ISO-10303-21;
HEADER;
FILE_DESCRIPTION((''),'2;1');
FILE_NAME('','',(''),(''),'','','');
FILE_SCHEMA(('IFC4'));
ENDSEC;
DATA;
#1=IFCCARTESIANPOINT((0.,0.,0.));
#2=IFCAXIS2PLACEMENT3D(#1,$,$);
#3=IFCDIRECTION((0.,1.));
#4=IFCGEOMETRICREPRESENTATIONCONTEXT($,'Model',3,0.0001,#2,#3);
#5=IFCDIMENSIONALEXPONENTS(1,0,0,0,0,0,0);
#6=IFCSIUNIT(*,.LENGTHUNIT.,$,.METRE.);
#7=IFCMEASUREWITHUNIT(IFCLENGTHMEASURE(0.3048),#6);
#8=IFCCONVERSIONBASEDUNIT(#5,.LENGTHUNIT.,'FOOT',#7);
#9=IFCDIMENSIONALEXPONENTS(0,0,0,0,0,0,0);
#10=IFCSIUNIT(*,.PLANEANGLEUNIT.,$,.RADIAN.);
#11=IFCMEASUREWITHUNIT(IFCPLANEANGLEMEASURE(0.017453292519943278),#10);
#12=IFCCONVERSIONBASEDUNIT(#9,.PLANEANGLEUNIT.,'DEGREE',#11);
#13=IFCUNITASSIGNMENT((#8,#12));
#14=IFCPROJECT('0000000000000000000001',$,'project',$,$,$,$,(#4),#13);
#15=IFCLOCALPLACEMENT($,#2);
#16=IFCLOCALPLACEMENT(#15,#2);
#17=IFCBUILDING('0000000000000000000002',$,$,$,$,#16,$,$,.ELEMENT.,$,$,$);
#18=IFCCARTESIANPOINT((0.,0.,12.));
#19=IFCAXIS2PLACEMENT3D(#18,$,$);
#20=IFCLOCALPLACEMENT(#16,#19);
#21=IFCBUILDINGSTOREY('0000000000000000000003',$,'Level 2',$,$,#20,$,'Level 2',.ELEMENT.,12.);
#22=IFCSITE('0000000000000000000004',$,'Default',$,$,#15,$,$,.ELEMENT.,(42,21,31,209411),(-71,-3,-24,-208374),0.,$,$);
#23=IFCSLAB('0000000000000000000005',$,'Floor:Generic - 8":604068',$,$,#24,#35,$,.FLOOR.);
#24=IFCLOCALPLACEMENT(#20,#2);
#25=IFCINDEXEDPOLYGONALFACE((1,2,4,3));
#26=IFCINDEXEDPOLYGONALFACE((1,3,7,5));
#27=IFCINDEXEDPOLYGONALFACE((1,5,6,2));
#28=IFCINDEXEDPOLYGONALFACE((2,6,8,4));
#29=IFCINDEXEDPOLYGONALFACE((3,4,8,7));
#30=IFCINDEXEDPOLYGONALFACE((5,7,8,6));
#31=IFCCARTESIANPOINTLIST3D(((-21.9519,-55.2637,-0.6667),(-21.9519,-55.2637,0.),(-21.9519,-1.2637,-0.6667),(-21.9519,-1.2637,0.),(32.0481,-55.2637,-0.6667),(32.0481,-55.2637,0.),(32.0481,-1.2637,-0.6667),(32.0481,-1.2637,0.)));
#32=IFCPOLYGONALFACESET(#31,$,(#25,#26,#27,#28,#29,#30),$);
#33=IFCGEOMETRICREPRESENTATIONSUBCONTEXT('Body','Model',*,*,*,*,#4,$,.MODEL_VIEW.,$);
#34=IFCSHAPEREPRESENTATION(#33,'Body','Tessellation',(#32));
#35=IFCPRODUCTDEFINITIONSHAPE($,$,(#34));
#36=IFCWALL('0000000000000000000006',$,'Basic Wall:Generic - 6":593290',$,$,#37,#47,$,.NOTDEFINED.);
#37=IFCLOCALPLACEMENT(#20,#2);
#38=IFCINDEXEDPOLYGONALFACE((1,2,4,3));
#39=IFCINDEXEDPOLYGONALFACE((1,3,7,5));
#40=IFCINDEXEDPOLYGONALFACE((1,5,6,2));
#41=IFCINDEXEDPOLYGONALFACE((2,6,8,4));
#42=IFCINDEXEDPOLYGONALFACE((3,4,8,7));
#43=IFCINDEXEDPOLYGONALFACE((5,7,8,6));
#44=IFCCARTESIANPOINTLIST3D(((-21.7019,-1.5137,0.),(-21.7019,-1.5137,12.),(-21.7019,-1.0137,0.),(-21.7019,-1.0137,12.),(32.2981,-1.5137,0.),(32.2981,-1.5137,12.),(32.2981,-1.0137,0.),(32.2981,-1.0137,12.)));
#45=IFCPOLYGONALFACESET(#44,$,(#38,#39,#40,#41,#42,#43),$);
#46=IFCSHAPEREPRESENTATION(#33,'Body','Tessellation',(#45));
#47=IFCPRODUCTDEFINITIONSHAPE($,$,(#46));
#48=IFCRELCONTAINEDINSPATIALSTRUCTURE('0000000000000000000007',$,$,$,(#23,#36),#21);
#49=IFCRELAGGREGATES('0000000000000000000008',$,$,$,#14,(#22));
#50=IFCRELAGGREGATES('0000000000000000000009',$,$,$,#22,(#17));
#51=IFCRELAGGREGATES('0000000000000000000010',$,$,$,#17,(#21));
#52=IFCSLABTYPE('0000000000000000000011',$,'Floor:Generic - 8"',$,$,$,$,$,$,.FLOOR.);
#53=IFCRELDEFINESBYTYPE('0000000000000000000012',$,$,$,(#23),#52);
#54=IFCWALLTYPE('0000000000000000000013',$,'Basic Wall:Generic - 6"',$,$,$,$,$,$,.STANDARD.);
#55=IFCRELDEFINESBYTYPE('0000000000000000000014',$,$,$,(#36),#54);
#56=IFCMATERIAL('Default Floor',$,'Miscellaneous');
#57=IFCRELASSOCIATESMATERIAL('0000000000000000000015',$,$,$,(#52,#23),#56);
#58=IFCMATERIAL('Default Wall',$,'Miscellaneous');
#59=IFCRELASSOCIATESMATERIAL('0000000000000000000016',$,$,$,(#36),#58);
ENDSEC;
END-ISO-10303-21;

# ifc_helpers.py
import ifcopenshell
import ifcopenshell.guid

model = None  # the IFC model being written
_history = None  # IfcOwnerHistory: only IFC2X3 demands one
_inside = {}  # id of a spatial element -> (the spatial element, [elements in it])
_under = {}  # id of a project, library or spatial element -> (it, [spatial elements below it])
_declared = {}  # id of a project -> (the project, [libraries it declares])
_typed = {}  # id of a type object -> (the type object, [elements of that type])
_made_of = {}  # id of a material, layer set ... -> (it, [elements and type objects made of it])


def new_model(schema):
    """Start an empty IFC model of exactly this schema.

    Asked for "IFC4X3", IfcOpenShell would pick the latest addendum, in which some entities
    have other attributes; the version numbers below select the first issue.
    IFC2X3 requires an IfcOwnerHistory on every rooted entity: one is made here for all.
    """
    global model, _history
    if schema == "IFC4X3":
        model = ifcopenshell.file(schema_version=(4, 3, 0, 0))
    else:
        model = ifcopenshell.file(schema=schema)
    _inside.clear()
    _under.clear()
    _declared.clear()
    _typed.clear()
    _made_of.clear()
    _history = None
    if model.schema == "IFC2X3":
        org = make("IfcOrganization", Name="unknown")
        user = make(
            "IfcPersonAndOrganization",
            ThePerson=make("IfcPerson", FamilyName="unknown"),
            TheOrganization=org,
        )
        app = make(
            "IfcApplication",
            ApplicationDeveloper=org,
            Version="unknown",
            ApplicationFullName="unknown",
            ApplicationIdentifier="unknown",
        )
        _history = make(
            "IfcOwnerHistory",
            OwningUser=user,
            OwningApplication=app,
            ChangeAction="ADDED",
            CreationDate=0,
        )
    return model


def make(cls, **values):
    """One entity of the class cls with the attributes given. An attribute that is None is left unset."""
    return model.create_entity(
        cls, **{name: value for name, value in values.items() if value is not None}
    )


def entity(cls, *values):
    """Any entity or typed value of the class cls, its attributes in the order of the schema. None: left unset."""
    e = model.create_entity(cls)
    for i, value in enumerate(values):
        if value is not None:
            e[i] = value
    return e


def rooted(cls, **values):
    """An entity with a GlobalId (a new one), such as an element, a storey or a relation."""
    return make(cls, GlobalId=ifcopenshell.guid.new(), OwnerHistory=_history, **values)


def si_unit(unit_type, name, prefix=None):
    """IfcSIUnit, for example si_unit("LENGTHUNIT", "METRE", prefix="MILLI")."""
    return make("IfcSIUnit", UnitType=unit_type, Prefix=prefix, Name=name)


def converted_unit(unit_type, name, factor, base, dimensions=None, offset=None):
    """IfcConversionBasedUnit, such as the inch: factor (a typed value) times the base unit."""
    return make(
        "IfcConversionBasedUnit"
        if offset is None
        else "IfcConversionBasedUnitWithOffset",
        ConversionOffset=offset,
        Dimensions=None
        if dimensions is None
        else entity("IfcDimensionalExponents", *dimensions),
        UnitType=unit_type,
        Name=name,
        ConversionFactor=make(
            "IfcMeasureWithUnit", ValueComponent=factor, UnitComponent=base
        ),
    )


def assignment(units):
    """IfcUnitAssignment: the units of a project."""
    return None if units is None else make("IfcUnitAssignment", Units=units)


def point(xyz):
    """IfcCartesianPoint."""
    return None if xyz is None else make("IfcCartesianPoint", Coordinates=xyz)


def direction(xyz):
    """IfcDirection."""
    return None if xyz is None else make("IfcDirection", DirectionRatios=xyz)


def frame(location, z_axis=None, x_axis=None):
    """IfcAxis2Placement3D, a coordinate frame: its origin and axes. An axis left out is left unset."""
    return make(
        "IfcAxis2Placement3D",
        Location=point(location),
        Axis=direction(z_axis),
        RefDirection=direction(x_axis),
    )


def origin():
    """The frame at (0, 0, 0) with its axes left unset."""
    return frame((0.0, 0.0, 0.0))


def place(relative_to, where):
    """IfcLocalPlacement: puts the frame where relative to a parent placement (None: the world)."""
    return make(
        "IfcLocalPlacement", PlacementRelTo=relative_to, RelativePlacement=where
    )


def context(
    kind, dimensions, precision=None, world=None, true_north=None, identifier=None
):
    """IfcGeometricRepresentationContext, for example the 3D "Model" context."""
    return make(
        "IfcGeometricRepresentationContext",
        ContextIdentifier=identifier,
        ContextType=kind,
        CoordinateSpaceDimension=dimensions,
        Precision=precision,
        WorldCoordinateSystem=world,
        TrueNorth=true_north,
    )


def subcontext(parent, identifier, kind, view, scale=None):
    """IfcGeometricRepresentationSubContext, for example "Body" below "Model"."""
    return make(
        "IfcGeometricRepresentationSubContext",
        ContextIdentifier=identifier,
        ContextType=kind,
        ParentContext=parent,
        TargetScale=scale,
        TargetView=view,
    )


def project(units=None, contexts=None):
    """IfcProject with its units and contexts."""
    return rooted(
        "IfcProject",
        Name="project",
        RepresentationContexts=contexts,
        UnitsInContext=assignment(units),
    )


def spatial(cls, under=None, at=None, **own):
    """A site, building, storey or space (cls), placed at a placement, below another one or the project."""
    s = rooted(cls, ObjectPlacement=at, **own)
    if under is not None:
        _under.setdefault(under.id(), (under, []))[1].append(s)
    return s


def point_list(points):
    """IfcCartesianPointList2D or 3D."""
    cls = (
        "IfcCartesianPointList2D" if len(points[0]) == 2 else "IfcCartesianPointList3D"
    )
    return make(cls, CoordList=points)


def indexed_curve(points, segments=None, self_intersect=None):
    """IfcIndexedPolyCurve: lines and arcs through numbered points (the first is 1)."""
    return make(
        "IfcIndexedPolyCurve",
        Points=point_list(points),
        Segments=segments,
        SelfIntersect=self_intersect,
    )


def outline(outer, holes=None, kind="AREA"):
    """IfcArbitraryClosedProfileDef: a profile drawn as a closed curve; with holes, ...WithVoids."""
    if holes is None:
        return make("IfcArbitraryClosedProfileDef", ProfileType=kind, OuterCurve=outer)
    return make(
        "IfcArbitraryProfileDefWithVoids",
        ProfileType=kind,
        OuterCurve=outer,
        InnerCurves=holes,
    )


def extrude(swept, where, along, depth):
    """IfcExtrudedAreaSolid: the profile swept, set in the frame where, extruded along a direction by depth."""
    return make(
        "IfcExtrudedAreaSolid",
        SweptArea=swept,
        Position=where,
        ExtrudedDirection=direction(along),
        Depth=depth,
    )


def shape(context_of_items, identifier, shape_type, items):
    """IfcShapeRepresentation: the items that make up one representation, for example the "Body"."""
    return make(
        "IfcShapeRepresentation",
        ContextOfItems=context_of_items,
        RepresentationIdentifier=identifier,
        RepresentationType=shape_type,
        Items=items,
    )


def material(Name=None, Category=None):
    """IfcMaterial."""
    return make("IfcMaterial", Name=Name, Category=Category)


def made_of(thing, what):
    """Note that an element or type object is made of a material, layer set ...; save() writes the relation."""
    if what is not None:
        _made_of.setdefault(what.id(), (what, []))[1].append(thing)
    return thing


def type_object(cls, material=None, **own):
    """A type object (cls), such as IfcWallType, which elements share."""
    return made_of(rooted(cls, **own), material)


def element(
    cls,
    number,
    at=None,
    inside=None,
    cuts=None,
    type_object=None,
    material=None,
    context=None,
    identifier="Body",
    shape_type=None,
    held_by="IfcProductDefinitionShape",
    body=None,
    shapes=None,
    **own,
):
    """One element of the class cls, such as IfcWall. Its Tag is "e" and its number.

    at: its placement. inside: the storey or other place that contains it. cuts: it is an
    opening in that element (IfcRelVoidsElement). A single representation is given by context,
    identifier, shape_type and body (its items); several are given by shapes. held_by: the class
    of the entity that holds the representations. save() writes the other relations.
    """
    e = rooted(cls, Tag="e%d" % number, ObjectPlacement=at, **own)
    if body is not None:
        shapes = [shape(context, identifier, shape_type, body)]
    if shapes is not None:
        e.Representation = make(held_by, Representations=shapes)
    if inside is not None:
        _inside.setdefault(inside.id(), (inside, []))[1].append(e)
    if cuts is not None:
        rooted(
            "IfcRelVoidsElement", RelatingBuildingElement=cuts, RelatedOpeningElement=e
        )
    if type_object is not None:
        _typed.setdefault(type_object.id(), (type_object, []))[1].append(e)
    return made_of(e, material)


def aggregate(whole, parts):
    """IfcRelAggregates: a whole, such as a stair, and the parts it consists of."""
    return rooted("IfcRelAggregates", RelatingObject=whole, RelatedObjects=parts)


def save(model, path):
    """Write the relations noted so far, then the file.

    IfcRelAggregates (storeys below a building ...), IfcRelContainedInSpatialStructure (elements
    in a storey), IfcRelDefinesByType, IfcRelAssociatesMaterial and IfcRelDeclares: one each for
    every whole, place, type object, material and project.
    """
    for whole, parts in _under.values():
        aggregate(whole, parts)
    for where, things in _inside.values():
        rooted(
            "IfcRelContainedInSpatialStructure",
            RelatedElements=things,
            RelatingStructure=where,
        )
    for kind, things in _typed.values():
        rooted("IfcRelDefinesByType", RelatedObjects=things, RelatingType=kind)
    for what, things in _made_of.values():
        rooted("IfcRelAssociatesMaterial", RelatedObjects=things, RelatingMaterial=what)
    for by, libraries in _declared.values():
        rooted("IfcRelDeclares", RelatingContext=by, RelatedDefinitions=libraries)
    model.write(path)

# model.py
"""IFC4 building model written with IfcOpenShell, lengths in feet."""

from ifc_helpers import new_model, entity, si_unit, converted_unit, direction, frame, origin, place, context, subcontext, project, spatial, indexed_curve, outline, extrude, material, type_object, element, save


model = new_model("IFC4")

# Units and contexts
model_context = context("Model", 3, precision=0.0001, world=origin(), true_north=direction((0.0, 1.0)))
body_context = subcontext(model_context, "Body", "Model", "MODEL_VIEW")
ifc_project = project(units=[converted_unit("LENGTHUNIT", "FOOT", entity("IfcLengthMeasure", 0.3048), si_unit("LENGTHUNIT", "METRE"), dimensions=[1, 0, 0, 0, 0, 0, 0]), converted_unit("PLANEANGLEUNIT", "DEGREE", entity("IfcPlaneAngleMeasure", 0.017453292519943278), si_unit("PLANEANGLEUNIT", "RADIAN"), dimensions=[0, 0, 0, 0, 0, 0, 0])], contexts=[model_context])

# Site, building, storey
site_placement = place(None, origin())
site = spatial("IfcSite", under=ifc_project, at=site_placement, Name="Default", CompositionType="ELEMENT", RefLatitude=(42, 21, 31, 209411), RefLongitude=(-71, -3, -24, -208374), RefElevation=0.0)
building_placement = place(site_placement, origin())
building = spatial("IfcBuilding", under=site, at=building_placement, CompositionType="ELEMENT")
storey_placement = place(building_placement, frame((0.0, 0.0, 12.0)))
storey = spatial("IfcBuildingStorey", under=building, at=storey_placement, Name="Level 2", LongName="Level 2", CompositionType="ELEMENT", Elevation=12.0)

# Slab
ifc_material_1 = material(Name="Default Floor", Category="Miscellaneous")
slab_type = type_object("IfcSlabType", Name="Floor:Generic - 8\"", PredefinedType="FLOOR", material=ifc_material_1)
slab_placement = place(storey_placement, origin())
element("IfcSlab", 1, at=slab_placement, inside=storey, type_object=slab_type, material=ifc_material_1, Name="Floor:Generic - 8\":604068", PredefinedType="FLOOR", context=body_context, shape_type="SweptSolid", body=[
    extrude(outline(indexed_curve([(-27.0, -27.0), (27.0, -27.0), (27.0, 27.0), (-27.0, 27.0), (-27.0, -27.0)], self_intersect=False)), frame((5.0481, -28.2637, 0.0), z_axis=(0.0, 0.0, -1.0), x_axis=(0.0, 1.0, 0.0)), (0.0, 0.0, 1.0), 0.6667),
])

# Wall
ifc_material_2 = material(Name="Default Wall", Category="Miscellaneous")
wall_type = type_object("IfcWallType", Name="Basic Wall:Generic - 6\"", PredefinedType="STANDARD")
wall_placement = place(storey_placement, frame((-21.7019, -1.2637, 0.0)))
element("IfcWall", 2, at=wall_placement, inside=storey, type_object=wall_type, material=ifc_material_2, Name="Basic Wall:Generic - 6\":593290", PredefinedType="NOTDEFINED", context=body_context, shape_type="SweptSolid", body=[
    extrude(outline(indexed_curve([(54.0, 0.25), (0.0, 0.25), (0.0, -0.25), (54.0, -0.25), (54.0, 0.25)], self_intersect=False)), origin(), (0.0, 0.0, 1.0), 12.0),
])

save(model, "model.ifc")
